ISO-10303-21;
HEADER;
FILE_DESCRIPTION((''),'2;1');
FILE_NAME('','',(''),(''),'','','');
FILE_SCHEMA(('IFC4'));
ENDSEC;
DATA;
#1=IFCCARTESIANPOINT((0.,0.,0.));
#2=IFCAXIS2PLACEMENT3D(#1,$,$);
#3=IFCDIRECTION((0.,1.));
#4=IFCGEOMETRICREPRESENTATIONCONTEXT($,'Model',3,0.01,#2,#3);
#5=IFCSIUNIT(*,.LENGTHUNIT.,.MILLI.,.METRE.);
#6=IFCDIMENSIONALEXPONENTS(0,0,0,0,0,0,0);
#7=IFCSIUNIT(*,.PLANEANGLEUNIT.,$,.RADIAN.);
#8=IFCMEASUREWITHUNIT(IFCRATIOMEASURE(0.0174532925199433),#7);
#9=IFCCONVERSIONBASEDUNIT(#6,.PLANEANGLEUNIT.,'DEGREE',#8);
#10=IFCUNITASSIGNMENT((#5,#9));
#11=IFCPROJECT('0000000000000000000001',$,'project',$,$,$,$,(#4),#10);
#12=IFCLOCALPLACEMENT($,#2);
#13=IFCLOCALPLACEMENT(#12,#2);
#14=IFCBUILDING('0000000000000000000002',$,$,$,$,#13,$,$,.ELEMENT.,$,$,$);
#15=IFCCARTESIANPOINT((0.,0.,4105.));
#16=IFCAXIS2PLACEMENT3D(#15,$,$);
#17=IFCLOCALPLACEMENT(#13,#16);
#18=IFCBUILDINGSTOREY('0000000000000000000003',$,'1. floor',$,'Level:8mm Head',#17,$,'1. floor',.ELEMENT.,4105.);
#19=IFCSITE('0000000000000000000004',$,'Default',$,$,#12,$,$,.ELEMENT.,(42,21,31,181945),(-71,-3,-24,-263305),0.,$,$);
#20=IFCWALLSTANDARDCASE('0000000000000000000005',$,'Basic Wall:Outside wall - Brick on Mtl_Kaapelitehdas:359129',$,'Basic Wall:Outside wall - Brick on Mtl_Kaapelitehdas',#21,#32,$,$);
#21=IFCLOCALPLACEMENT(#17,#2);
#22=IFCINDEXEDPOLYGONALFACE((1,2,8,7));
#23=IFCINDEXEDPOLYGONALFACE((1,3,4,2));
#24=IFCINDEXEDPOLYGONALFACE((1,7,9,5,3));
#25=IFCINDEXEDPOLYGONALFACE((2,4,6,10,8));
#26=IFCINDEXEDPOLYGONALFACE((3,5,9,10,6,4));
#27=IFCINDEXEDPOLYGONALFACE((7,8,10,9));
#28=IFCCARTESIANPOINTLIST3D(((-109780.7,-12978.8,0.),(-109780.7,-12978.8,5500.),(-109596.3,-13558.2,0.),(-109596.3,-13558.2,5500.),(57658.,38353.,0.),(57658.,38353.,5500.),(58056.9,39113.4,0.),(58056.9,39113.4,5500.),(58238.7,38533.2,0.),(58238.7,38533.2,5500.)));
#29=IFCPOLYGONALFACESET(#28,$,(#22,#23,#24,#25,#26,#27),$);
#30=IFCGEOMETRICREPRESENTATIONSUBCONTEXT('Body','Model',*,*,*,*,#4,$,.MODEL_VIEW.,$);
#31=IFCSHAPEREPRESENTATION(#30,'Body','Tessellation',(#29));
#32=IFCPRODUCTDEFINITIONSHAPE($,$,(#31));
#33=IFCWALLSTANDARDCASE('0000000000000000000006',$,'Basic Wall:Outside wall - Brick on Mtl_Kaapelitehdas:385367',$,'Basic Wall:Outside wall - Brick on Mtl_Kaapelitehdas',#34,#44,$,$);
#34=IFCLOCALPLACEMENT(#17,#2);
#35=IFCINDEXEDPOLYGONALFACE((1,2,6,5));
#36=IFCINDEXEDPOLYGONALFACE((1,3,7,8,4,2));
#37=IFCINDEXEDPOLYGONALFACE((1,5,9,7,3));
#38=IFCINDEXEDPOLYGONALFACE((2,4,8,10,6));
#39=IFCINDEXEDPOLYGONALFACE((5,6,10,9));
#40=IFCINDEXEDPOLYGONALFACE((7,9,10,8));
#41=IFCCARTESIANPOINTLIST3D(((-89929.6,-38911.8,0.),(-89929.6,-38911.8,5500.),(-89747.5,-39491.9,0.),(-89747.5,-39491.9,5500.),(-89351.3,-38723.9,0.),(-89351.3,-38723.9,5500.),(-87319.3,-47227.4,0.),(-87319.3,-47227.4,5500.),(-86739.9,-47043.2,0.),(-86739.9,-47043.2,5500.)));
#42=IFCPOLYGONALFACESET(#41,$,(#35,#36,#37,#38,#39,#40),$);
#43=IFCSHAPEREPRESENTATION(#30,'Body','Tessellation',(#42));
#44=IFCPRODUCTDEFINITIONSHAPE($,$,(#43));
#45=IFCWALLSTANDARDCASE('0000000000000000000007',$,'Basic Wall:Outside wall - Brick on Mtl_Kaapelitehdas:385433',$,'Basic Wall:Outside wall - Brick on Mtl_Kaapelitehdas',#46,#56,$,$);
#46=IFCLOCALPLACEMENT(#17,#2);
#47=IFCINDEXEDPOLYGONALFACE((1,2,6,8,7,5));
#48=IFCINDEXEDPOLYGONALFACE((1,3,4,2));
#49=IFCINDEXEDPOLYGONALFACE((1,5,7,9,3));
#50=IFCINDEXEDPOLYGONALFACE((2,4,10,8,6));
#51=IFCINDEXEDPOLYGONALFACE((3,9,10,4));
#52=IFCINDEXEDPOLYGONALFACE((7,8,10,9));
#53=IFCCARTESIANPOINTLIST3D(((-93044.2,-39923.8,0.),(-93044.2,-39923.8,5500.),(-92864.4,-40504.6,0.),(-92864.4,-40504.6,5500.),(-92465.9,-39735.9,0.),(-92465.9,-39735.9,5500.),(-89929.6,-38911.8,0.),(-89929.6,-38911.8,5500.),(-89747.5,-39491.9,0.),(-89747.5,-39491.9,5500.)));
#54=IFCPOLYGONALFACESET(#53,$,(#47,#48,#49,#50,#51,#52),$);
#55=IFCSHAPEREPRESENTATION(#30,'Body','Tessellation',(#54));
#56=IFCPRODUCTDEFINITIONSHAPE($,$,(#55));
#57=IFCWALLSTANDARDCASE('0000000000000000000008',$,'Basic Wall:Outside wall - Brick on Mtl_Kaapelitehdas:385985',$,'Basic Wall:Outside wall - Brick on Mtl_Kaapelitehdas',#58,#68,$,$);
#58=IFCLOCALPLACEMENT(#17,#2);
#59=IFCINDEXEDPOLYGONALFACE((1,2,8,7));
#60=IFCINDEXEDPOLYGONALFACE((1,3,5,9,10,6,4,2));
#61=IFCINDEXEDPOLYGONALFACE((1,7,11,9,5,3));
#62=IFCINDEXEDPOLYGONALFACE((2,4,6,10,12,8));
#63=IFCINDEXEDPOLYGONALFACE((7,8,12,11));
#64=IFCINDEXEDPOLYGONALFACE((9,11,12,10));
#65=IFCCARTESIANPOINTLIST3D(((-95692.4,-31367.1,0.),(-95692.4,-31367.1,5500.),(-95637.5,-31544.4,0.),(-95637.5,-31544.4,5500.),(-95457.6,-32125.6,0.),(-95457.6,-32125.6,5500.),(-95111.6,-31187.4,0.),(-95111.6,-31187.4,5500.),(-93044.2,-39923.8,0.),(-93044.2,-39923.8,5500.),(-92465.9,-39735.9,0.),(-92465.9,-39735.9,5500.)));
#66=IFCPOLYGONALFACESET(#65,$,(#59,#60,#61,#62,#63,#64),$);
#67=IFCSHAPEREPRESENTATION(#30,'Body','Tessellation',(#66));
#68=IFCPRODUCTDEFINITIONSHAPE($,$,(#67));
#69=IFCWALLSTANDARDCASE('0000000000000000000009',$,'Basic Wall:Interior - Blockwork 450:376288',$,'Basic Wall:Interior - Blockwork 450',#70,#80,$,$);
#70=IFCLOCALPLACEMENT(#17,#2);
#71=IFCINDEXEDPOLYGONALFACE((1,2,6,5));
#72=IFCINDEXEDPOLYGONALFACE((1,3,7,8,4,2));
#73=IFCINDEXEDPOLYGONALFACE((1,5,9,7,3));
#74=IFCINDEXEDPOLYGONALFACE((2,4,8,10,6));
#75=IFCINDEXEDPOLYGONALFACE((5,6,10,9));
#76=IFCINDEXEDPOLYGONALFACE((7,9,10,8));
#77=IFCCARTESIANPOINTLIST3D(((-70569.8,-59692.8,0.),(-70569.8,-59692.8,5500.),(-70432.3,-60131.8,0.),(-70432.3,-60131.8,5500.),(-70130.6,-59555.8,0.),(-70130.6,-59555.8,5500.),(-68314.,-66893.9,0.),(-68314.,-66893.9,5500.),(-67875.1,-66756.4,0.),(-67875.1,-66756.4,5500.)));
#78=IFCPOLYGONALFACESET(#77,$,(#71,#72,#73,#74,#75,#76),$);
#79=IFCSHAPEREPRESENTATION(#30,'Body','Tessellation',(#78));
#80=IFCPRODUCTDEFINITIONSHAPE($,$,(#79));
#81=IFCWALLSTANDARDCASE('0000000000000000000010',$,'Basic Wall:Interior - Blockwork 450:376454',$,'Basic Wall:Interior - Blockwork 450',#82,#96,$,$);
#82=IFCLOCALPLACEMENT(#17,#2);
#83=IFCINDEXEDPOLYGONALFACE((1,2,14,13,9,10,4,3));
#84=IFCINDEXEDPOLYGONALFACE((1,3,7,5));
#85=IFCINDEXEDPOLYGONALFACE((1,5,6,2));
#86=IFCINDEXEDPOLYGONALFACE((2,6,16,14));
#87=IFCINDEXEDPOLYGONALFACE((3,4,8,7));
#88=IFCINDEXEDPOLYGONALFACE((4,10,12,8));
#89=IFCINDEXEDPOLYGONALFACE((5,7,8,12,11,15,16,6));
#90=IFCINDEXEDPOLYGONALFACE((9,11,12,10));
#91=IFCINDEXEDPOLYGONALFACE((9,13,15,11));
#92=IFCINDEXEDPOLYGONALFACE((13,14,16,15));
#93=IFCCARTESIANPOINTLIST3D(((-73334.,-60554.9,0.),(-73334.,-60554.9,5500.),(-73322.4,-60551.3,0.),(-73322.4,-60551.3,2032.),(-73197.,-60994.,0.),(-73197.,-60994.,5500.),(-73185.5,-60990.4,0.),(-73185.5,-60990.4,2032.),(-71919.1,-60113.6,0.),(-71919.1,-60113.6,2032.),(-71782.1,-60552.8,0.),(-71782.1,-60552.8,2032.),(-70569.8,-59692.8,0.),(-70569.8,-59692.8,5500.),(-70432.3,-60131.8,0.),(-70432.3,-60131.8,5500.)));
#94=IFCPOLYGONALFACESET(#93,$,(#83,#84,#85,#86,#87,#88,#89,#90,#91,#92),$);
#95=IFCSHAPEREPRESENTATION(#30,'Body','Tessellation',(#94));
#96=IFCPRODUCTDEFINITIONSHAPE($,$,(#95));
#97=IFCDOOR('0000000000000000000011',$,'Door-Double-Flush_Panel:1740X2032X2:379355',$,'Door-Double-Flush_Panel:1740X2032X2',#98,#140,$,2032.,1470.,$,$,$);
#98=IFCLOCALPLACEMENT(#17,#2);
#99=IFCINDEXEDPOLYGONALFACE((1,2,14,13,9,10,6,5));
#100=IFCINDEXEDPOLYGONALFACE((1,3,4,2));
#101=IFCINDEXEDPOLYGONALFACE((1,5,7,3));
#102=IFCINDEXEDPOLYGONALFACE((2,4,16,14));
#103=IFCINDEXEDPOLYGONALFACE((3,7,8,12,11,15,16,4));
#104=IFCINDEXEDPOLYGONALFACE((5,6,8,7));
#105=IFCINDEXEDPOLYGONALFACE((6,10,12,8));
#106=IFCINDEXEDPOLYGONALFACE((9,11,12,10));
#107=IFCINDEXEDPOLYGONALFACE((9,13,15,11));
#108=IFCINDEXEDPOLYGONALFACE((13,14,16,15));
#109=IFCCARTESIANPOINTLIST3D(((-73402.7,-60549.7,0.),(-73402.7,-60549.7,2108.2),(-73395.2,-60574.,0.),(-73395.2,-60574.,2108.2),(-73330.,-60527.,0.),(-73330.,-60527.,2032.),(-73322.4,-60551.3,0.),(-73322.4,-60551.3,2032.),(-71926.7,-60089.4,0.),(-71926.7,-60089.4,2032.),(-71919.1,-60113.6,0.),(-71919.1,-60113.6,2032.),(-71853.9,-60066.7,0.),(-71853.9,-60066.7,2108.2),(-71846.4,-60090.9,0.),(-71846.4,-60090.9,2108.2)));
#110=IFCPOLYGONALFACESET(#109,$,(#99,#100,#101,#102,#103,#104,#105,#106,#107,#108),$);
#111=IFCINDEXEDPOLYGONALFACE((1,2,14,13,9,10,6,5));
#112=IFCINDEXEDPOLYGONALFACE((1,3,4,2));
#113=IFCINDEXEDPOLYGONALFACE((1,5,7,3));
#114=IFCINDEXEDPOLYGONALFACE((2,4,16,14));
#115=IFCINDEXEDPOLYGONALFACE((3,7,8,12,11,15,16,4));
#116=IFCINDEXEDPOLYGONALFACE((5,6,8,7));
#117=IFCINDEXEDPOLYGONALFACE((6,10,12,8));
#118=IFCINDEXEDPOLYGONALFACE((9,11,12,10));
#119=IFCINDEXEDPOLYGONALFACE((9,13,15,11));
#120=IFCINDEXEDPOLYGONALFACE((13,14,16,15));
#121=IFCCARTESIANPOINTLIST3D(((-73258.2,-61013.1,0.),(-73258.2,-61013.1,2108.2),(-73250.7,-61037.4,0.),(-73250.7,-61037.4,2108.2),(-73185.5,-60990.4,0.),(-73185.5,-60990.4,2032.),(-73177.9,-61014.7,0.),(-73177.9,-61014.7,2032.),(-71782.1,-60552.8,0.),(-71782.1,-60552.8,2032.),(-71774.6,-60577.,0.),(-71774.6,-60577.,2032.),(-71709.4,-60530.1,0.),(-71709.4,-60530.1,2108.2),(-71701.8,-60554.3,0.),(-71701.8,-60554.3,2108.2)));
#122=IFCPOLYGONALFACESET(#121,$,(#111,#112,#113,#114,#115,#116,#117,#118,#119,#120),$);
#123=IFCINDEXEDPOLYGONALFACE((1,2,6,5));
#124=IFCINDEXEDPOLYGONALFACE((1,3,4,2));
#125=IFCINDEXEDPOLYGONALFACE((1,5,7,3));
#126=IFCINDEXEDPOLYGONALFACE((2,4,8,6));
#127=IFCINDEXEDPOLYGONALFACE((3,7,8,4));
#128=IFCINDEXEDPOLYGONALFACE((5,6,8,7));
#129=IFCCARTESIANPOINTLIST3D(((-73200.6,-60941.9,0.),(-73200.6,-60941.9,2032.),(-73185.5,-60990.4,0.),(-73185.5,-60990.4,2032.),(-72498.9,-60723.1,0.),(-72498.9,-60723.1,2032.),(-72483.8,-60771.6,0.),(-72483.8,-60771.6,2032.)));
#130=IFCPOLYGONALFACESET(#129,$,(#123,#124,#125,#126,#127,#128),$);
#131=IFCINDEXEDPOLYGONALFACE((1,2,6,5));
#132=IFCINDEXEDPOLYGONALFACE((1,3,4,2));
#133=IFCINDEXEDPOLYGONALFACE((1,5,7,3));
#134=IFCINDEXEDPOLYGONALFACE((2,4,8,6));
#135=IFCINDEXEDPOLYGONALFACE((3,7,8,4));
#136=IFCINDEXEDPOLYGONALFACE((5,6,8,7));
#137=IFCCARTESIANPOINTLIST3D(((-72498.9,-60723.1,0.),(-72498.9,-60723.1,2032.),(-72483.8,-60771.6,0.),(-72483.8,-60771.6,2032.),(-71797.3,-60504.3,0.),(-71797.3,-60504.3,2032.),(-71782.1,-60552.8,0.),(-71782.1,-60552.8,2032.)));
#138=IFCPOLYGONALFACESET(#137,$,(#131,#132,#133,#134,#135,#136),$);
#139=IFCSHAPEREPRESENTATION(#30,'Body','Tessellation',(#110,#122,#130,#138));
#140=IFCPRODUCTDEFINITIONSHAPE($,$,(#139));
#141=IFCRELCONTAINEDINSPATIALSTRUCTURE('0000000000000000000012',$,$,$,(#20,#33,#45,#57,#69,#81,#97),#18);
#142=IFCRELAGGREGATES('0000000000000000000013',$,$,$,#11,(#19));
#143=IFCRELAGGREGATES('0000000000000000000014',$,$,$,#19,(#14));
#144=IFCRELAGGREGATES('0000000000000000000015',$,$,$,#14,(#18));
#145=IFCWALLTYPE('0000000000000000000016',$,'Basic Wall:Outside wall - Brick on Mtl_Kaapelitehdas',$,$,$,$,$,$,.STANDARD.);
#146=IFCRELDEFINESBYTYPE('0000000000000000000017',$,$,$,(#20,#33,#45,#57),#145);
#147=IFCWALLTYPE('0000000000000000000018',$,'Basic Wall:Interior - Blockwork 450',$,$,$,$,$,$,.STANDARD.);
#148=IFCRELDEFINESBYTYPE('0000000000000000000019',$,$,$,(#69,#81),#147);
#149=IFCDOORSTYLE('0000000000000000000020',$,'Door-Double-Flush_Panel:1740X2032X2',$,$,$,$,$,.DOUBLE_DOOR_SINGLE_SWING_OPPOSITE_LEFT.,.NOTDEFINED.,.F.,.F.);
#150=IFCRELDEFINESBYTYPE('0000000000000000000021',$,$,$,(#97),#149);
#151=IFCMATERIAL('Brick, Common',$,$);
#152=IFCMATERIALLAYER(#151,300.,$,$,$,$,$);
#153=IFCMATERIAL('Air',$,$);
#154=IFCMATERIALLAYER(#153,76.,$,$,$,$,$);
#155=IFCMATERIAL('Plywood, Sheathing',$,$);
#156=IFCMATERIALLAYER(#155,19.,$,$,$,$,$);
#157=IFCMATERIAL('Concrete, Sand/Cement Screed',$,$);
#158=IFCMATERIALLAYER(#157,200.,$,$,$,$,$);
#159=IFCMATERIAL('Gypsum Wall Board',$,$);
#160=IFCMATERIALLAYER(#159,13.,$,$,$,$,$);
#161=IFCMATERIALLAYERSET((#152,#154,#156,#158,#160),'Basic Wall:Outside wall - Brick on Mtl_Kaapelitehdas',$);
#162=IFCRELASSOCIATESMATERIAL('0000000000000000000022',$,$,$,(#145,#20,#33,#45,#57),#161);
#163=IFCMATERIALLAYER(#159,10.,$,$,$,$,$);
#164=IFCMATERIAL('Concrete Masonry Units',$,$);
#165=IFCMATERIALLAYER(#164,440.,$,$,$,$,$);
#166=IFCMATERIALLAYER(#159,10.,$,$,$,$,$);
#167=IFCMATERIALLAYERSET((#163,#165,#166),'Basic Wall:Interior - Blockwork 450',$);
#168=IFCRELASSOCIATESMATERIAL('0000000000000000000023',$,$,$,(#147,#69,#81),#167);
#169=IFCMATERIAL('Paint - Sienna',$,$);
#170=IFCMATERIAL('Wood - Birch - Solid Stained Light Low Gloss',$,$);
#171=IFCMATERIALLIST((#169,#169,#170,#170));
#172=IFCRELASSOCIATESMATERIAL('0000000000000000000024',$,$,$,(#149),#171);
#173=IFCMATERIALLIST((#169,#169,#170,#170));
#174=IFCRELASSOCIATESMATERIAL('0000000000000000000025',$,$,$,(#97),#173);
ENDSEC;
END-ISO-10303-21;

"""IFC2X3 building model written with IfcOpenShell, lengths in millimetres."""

from ifc_helpers import new_model, entity, si_unit, converted_unit, direction, frame, frame_2d, origin, place, context, subcontext, project, spatial, polyline, rectangle, outline, extrude, source, transform, mapped, material, material_list, layer, layer_set, layer_usage, type_object, type_shapes, element, fill, save


model = new_model("IFC2X3")

# Units and contexts
model_context = context("Model", 3, precision=0.01, world=origin(), true_north=direction((0.0, 1.0)))
body_context = subcontext(model_context, "Body", "Model", "MODEL_VIEW")
ifc_project = project(units=[si_unit("LENGTHUNIT", "METRE", prefix="MILLI"), converted_unit("PLANEANGLEUNIT", "DEGREE", entity("IfcRatioMeasure", 0.0174532925199433), si_unit("PLANEANGLEUNIT", "RADIAN"), dimensions=[0, 0, 0, 0, 0, 0, 0])], contexts=[model_context])

# Site, building, storey
site_placement = place(None, origin())
site = spatial("IfcSite", under=ifc_project, at=site_placement, Name="Default", CompositionType="ELEMENT", RefLatitude=(42, 21, 31, 181945), RefLongitude=(-71, -3, -24, -263305), RefElevation=0.0)
building_placement = place(site_placement, origin())
building = spatial("IfcBuilding", under=site, at=building_placement, CompositionType="ELEMENT")
storey_placement = place(building_placement, frame((0.0, 0.0, 4105.0)))
storey = spatial("IfcBuildingStorey", under=building, at=storey_placement, Name="1. floor", ObjectType="Level:8mm Head", LongName="1. floor", CompositionType="ELEMENT", Elevation=4105.0)

# Walls
ifc_material_1 = material(Name="Brick, Common")
ifc_layer_1 = layer(ifc_material_1, 300.0)
ifc_material_2 = material(Name="Air")
ifc_layer_2 = layer(ifc_material_2, 76.0)
ifc_material_3 = material(Name="Plywood, Sheathing")
ifc_layer_3 = layer(ifc_material_3, 19.0)
ifc_material_4 = material(Name="Concrete, Sand/Cement Screed")
ifc_layer_4 = layer(ifc_material_4, 200.0)
ifc_material_5 = material(Name="Gypsum Wall Board")
ifc_layer_5 = layer(ifc_material_5, 13.0)
ifc_layer_set_1 = layer_set([ifc_layer_1, ifc_layer_2, ifc_layer_3, ifc_layer_4, ifc_layer_5], Name="Basic Wall:Outside wall - Brick on Mtl_Kaapelitehdas")
wall_type_1 = type_object("IfcWallType", Name="Basic Wall:Outside wall - Brick on Mtl_Kaapelitehdas", PredefinedType="STANDARD", material=ifc_layer_set_1)
ifc_layer_usage_1 = layer_usage(ifc_layer_set_1, "AXIS2", "NEGATIVE", 304.0)
wall_1_placement = place(storey_placement, frame((-109690.6, -13269.2, 0.0), z_axis=(0.0, 0.0, 1.0), x_axis=(0.955057, 0.296424, 0.0)))
element("IfcWallStandardCase", 1, at=wall_1_placement, inside=storey, type_object=wall_type_1, material=ifc_layer_usage_1, Name="Basic Wall:Outside wall - Brick on Mtl_Kaapelitehdas:359129", ObjectType="Basic Wall:Outside wall - Brick on Mtl_Kaapelitehdas", context=body_context, shape_type="SweptSolid", body=[
    extrude(outline(polyline([(175737.4, -304.0), (175735.8, 304.0), (0.0, 304.0), (4.3, -304.0), (175129.4, -304.0), (175737.4, -304.0)])), origin(), (0.0, 0.0, 1.0), 5500.0),
])
ifc_layer_usage_2 = layer_usage(ifc_layer_set_1, "AXIS2", "NEGATIVE", 304.0)
wall_2_placement = place(storey_placement, frame((-87029.3, -47136.3, 0.0), z_axis=(0.0, 0.0, 1.0), x_axis=(-0.299495, 0.954098, 0.0)))
element("IfcWallStandardCase", 2, at=wall_2_placement, inside=storey, type_object=wall_type_1, material=ifc_layer_usage_2, Name="Basic Wall:Outside wall - Brick on Mtl_Kaapelitehdas:385367", ObjectType="Basic Wall:Outside wall - Brick on Mtl_Kaapelitehdas", context=body_context, shape_type="SweptSolid", body=[
    extrude(outline(polyline([(8721.8, -304.0), (8715.7, 304.0), (8107.6, 304.0), (0.0, 304.0), (2.2, -304.0), (8721.8, -304.0)])), origin(), (0.0, 0.0, 1.0), 5500.0),
])
ifc_layer_usage_3 = layer_usage(ifc_layer_set_1, "AXIS2", "NEGATIVE", 304.0)
wall_3_placement = place(storey_placement, frame((-89835.7, -39200.9, 0.0), z_axis=(0.0, 0.0, 1.0), x_axis=(-0.951057, -0.309017, 0.0)))
element("IfcWallStandardCase", 3, at=wall_3_placement, inside=storey, type_object=wall_type_1, material=ifc_layer_usage_3, Name="Basic Wall:Outside wall - Brick on Mtl_Kaapelitehdas:385433", ObjectType="Basic Wall:Outside wall - Brick on Mtl_Kaapelitehdas", context=body_context, shape_type="SweptSolid", body=[
    extrude(outline(polyline([(3274.9, -304.0), (3283.4, 304.0), (6.1, 304.0), (0.0, -304.0), (2666.8, -304.0), (3274.9, -304.0)])), origin(), (0.0, 0.0, 1.0), 5500.0),
])
ifc_layer_usage_4 = layer_usage(ifc_layer_set_1, "AXIS2", "NEGATIVE", 304.0)
wall_4_placement = place(storey_placement, frame((-92753.8, -39833.9, 0.0), z_axis=(0.0, 0.0, 1.0), x_axis=(-0.295652, 0.955296, 0.0)))
element("IfcWallStandardCase", 4, at=wall_4_placement, inside=storey, type_object=wall_type_1, material=ifc_layer_usage_4, Name="Basic Wall:Outside wall - Brick on Mtl_Kaapelitehdas:385985", ObjectType="Basic Wall:Outside wall - Brick on Mtl_Kaapelitehdas", context=body_context, shape_type="SweptSolid", body=[
    extrude(outline(polyline([(8957.0, -304.0), (8957.0, 304.0), (8771.5, 304.0), (8163.0, 304.0), (0.0, 304.0), (8.5, -304.0), (8957.0, -304.0)])), origin(), (0.0, 0.0, 1.0), 5500.0),
])
ifc_layer_6 = layer(ifc_material_5, 10.0)
ifc_material_6 = material(Name="Concrete Masonry Units")
ifc_layer_7 = layer(ifc_material_6, 440.0)
ifc_layer_8 = layer(ifc_material_5, 10.0)
ifc_layer_set_2 = layer_set([ifc_layer_6, ifc_layer_7, ifc_layer_8], Name="Basic Wall:Interior - Blockwork 450")
ifc_layer_usage_5 = layer_usage(ifc_layer_set_2, "AXIS2", "NEGATIVE", 230.0)
wall_type_2 = type_object("IfcWallType", Name="Basic Wall:Interior - Blockwork 450", PredefinedType="STANDARD", material=ifc_layer_set_2)
wall_5_placement = place(storey_placement, frame((-70350.3, -59624.0, 0.0), z_axis=(0.0, 0.0, 1.0), x_axis=(0.298924, -0.954277, 0.0)))
element("IfcWallStandardCase", 5, at=wall_5_placement, inside=storey, type_object=wall_type_2, material=ifc_layer_usage_5, Name="Basic Wall:Interior - Blockwork 450:376288", ObjectType="Basic Wall:Interior - Blockwork 450", context=body_context, shape_type="SweptSolid", body=[
    extrude(outline(polyline([(7546.2, -230.0), (7546.2, 230.0), (0.6, 230.0), (0.0, -230.0), (460.0, -230.0), (7546.2, -230.0)])), origin(), (0.0, 0.0, 1.0), 5500.0),
])

# Wall, opening, door
ifc_layer_usage_6 = layer_usage(ifc_layer_set_2, "AXIS2", "NEGATIVE", 230.0)
wall_6_placement = place(storey_placement, frame((-70500.7, -59912.2, 0.0), z_axis=(0.0, 0.0, 1.0), x_axis=(-0.954648, -0.297735, 0.0)))
wall_6 = element("IfcWallStandardCase", 6, at=wall_6_placement, inside=storey, type_object=wall_type_2, material=ifc_layer_usage_6, Name="Basic Wall:Interior - Blockwork 450:376454", ObjectType="Basic Wall:Interior - Blockwork 450", context=body_context, shape_type="SweptSolid", body=[
    extrude(outline(polyline([(0.6, -230.0), (2896.1, -230.0), (2896.1, 230.0), (0.0, 230.0), (0.6, -230.0)])), origin(), (0.0, 0.0, 1.0), 5500.0),
])
opening_placement = place(wall_6_placement, frame((1414.0, -230.0, 0.0)))
opening = element("IfcOpeningElement", 7, at=opening_placement, cuts=wall_6, ObjectType="Opening", context=body_context, shape_type="SweptSolid", body=[
    extrude(rectangle(XDim=2032.0, YDim=1470.0, at=frame_2d((1016.0, 735.0), x_axis=(1.0, 0.0))), frame((0.0, 0.0, 0.0), z_axis=(0.0, 1.0, 0.0), x_axis=(0.0, 0.0, 1.0)), (0.0, 0.0, 1.0), 460.0),
])
ifc_material_7 = material(Name="Paint - Sienna")
ifc_material_8 = material(Name="Wood - Birch - Solid Stained Light Low Gloss")
ifc_material_list_1 = material_list([ifc_material_7, ifc_material_7, ifc_material_8, ifc_material_8])
ifc_material_list_2 = material_list([ifc_material_7, ifc_material_7, ifc_material_8, ifc_material_8])
door_style = type_object("IfcDoorStyle", Name="Door-Double-Flush_Panel:1740X2032X2", ConstructionType="NOTDEFINED", OperationType="DOUBLE_DOOR_SINGLE_SWING_OPPOSITE_LEFT", ParameterTakesPrecedence=False, Sizeable=False, material=ifc_material_list_2)
shared_shape = source(origin(), body_context, "Body", "SweptSolid", [
    extrude(outline(polyline([(-997.0, 735.0), (1035.0, 735.0), (1035.0, 811.2), (-1073.2, 811.2), (-1073.2, -811.2), (1035.0, -811.2), (1035.0, -735.0), (-997.0, -735.0), (-997.0, 735.0)])), frame((735.0, -25.4, 1035.0), z_axis=(0.0, 1.0, 0.0), x_axis=(0.0, 0.0, -1.0)), (0.0, 0.0, 1.0), 25.4),
    extrude(outline(polyline([(-997.0, 735.0), (1035.0, 735.0), (1035.0, 811.2), (-1073.2, 811.2), (-1073.2, -811.2), (1035.0, -811.2), (1035.0, -735.0), (-997.0, -735.0), (-997.0, 735.0)])), frame((735.0, 460.0, 1035.0), z_axis=(0.0, 1.0, 0.0), x_axis=(0.0, 0.0, -1.0)), (0.0, 0.0, 1.0), 25.4),
    extrude(rectangle(XDim=50.8, YDim=735.0, at=frame_2d((0.0, 0.0), x_axis=(1.0, 0.0))), frame((1102.5, 434.6, 0.0), z_axis=(0.0, 0.0, 1.0), x_axis=(0.0, -1.0, 0.0)), (0.0, 0.0, 1.0), 2032.0),
    extrude(rectangle(XDim=50.8, YDim=735.0, at=frame_2d((0.0, 0.0), x_axis=(1.0, 0.0))), frame((367.5, 434.6, 0.0), z_axis=(0.0, 0.0, 1.0), x_axis=(0.0, -1.0, 0.0)), (0.0, 0.0, 1.0), 2032.0),
])
type_shapes(door_style, [shared_shape])
door_placement = place(opening_placement, origin())
door = element("IfcDoor", 8, at=door_placement, inside=storey, type_object=door_style, material=ifc_material_list_1, Name="Door-Double-Flush_Panel:1740X2032X2:379355", ObjectType="Door-Double-Flush_Panel:1740X2032X2", OverallHeight=2032.0, OverallWidth=1470.0, context=body_context, shape_type="MappedRepresentation", body=[
    mapped(shared_shape, transform((0.0, 0.0, 0.0), scale=1.0)),
])
fill(opening, door)

save(model, "model.ifc")
